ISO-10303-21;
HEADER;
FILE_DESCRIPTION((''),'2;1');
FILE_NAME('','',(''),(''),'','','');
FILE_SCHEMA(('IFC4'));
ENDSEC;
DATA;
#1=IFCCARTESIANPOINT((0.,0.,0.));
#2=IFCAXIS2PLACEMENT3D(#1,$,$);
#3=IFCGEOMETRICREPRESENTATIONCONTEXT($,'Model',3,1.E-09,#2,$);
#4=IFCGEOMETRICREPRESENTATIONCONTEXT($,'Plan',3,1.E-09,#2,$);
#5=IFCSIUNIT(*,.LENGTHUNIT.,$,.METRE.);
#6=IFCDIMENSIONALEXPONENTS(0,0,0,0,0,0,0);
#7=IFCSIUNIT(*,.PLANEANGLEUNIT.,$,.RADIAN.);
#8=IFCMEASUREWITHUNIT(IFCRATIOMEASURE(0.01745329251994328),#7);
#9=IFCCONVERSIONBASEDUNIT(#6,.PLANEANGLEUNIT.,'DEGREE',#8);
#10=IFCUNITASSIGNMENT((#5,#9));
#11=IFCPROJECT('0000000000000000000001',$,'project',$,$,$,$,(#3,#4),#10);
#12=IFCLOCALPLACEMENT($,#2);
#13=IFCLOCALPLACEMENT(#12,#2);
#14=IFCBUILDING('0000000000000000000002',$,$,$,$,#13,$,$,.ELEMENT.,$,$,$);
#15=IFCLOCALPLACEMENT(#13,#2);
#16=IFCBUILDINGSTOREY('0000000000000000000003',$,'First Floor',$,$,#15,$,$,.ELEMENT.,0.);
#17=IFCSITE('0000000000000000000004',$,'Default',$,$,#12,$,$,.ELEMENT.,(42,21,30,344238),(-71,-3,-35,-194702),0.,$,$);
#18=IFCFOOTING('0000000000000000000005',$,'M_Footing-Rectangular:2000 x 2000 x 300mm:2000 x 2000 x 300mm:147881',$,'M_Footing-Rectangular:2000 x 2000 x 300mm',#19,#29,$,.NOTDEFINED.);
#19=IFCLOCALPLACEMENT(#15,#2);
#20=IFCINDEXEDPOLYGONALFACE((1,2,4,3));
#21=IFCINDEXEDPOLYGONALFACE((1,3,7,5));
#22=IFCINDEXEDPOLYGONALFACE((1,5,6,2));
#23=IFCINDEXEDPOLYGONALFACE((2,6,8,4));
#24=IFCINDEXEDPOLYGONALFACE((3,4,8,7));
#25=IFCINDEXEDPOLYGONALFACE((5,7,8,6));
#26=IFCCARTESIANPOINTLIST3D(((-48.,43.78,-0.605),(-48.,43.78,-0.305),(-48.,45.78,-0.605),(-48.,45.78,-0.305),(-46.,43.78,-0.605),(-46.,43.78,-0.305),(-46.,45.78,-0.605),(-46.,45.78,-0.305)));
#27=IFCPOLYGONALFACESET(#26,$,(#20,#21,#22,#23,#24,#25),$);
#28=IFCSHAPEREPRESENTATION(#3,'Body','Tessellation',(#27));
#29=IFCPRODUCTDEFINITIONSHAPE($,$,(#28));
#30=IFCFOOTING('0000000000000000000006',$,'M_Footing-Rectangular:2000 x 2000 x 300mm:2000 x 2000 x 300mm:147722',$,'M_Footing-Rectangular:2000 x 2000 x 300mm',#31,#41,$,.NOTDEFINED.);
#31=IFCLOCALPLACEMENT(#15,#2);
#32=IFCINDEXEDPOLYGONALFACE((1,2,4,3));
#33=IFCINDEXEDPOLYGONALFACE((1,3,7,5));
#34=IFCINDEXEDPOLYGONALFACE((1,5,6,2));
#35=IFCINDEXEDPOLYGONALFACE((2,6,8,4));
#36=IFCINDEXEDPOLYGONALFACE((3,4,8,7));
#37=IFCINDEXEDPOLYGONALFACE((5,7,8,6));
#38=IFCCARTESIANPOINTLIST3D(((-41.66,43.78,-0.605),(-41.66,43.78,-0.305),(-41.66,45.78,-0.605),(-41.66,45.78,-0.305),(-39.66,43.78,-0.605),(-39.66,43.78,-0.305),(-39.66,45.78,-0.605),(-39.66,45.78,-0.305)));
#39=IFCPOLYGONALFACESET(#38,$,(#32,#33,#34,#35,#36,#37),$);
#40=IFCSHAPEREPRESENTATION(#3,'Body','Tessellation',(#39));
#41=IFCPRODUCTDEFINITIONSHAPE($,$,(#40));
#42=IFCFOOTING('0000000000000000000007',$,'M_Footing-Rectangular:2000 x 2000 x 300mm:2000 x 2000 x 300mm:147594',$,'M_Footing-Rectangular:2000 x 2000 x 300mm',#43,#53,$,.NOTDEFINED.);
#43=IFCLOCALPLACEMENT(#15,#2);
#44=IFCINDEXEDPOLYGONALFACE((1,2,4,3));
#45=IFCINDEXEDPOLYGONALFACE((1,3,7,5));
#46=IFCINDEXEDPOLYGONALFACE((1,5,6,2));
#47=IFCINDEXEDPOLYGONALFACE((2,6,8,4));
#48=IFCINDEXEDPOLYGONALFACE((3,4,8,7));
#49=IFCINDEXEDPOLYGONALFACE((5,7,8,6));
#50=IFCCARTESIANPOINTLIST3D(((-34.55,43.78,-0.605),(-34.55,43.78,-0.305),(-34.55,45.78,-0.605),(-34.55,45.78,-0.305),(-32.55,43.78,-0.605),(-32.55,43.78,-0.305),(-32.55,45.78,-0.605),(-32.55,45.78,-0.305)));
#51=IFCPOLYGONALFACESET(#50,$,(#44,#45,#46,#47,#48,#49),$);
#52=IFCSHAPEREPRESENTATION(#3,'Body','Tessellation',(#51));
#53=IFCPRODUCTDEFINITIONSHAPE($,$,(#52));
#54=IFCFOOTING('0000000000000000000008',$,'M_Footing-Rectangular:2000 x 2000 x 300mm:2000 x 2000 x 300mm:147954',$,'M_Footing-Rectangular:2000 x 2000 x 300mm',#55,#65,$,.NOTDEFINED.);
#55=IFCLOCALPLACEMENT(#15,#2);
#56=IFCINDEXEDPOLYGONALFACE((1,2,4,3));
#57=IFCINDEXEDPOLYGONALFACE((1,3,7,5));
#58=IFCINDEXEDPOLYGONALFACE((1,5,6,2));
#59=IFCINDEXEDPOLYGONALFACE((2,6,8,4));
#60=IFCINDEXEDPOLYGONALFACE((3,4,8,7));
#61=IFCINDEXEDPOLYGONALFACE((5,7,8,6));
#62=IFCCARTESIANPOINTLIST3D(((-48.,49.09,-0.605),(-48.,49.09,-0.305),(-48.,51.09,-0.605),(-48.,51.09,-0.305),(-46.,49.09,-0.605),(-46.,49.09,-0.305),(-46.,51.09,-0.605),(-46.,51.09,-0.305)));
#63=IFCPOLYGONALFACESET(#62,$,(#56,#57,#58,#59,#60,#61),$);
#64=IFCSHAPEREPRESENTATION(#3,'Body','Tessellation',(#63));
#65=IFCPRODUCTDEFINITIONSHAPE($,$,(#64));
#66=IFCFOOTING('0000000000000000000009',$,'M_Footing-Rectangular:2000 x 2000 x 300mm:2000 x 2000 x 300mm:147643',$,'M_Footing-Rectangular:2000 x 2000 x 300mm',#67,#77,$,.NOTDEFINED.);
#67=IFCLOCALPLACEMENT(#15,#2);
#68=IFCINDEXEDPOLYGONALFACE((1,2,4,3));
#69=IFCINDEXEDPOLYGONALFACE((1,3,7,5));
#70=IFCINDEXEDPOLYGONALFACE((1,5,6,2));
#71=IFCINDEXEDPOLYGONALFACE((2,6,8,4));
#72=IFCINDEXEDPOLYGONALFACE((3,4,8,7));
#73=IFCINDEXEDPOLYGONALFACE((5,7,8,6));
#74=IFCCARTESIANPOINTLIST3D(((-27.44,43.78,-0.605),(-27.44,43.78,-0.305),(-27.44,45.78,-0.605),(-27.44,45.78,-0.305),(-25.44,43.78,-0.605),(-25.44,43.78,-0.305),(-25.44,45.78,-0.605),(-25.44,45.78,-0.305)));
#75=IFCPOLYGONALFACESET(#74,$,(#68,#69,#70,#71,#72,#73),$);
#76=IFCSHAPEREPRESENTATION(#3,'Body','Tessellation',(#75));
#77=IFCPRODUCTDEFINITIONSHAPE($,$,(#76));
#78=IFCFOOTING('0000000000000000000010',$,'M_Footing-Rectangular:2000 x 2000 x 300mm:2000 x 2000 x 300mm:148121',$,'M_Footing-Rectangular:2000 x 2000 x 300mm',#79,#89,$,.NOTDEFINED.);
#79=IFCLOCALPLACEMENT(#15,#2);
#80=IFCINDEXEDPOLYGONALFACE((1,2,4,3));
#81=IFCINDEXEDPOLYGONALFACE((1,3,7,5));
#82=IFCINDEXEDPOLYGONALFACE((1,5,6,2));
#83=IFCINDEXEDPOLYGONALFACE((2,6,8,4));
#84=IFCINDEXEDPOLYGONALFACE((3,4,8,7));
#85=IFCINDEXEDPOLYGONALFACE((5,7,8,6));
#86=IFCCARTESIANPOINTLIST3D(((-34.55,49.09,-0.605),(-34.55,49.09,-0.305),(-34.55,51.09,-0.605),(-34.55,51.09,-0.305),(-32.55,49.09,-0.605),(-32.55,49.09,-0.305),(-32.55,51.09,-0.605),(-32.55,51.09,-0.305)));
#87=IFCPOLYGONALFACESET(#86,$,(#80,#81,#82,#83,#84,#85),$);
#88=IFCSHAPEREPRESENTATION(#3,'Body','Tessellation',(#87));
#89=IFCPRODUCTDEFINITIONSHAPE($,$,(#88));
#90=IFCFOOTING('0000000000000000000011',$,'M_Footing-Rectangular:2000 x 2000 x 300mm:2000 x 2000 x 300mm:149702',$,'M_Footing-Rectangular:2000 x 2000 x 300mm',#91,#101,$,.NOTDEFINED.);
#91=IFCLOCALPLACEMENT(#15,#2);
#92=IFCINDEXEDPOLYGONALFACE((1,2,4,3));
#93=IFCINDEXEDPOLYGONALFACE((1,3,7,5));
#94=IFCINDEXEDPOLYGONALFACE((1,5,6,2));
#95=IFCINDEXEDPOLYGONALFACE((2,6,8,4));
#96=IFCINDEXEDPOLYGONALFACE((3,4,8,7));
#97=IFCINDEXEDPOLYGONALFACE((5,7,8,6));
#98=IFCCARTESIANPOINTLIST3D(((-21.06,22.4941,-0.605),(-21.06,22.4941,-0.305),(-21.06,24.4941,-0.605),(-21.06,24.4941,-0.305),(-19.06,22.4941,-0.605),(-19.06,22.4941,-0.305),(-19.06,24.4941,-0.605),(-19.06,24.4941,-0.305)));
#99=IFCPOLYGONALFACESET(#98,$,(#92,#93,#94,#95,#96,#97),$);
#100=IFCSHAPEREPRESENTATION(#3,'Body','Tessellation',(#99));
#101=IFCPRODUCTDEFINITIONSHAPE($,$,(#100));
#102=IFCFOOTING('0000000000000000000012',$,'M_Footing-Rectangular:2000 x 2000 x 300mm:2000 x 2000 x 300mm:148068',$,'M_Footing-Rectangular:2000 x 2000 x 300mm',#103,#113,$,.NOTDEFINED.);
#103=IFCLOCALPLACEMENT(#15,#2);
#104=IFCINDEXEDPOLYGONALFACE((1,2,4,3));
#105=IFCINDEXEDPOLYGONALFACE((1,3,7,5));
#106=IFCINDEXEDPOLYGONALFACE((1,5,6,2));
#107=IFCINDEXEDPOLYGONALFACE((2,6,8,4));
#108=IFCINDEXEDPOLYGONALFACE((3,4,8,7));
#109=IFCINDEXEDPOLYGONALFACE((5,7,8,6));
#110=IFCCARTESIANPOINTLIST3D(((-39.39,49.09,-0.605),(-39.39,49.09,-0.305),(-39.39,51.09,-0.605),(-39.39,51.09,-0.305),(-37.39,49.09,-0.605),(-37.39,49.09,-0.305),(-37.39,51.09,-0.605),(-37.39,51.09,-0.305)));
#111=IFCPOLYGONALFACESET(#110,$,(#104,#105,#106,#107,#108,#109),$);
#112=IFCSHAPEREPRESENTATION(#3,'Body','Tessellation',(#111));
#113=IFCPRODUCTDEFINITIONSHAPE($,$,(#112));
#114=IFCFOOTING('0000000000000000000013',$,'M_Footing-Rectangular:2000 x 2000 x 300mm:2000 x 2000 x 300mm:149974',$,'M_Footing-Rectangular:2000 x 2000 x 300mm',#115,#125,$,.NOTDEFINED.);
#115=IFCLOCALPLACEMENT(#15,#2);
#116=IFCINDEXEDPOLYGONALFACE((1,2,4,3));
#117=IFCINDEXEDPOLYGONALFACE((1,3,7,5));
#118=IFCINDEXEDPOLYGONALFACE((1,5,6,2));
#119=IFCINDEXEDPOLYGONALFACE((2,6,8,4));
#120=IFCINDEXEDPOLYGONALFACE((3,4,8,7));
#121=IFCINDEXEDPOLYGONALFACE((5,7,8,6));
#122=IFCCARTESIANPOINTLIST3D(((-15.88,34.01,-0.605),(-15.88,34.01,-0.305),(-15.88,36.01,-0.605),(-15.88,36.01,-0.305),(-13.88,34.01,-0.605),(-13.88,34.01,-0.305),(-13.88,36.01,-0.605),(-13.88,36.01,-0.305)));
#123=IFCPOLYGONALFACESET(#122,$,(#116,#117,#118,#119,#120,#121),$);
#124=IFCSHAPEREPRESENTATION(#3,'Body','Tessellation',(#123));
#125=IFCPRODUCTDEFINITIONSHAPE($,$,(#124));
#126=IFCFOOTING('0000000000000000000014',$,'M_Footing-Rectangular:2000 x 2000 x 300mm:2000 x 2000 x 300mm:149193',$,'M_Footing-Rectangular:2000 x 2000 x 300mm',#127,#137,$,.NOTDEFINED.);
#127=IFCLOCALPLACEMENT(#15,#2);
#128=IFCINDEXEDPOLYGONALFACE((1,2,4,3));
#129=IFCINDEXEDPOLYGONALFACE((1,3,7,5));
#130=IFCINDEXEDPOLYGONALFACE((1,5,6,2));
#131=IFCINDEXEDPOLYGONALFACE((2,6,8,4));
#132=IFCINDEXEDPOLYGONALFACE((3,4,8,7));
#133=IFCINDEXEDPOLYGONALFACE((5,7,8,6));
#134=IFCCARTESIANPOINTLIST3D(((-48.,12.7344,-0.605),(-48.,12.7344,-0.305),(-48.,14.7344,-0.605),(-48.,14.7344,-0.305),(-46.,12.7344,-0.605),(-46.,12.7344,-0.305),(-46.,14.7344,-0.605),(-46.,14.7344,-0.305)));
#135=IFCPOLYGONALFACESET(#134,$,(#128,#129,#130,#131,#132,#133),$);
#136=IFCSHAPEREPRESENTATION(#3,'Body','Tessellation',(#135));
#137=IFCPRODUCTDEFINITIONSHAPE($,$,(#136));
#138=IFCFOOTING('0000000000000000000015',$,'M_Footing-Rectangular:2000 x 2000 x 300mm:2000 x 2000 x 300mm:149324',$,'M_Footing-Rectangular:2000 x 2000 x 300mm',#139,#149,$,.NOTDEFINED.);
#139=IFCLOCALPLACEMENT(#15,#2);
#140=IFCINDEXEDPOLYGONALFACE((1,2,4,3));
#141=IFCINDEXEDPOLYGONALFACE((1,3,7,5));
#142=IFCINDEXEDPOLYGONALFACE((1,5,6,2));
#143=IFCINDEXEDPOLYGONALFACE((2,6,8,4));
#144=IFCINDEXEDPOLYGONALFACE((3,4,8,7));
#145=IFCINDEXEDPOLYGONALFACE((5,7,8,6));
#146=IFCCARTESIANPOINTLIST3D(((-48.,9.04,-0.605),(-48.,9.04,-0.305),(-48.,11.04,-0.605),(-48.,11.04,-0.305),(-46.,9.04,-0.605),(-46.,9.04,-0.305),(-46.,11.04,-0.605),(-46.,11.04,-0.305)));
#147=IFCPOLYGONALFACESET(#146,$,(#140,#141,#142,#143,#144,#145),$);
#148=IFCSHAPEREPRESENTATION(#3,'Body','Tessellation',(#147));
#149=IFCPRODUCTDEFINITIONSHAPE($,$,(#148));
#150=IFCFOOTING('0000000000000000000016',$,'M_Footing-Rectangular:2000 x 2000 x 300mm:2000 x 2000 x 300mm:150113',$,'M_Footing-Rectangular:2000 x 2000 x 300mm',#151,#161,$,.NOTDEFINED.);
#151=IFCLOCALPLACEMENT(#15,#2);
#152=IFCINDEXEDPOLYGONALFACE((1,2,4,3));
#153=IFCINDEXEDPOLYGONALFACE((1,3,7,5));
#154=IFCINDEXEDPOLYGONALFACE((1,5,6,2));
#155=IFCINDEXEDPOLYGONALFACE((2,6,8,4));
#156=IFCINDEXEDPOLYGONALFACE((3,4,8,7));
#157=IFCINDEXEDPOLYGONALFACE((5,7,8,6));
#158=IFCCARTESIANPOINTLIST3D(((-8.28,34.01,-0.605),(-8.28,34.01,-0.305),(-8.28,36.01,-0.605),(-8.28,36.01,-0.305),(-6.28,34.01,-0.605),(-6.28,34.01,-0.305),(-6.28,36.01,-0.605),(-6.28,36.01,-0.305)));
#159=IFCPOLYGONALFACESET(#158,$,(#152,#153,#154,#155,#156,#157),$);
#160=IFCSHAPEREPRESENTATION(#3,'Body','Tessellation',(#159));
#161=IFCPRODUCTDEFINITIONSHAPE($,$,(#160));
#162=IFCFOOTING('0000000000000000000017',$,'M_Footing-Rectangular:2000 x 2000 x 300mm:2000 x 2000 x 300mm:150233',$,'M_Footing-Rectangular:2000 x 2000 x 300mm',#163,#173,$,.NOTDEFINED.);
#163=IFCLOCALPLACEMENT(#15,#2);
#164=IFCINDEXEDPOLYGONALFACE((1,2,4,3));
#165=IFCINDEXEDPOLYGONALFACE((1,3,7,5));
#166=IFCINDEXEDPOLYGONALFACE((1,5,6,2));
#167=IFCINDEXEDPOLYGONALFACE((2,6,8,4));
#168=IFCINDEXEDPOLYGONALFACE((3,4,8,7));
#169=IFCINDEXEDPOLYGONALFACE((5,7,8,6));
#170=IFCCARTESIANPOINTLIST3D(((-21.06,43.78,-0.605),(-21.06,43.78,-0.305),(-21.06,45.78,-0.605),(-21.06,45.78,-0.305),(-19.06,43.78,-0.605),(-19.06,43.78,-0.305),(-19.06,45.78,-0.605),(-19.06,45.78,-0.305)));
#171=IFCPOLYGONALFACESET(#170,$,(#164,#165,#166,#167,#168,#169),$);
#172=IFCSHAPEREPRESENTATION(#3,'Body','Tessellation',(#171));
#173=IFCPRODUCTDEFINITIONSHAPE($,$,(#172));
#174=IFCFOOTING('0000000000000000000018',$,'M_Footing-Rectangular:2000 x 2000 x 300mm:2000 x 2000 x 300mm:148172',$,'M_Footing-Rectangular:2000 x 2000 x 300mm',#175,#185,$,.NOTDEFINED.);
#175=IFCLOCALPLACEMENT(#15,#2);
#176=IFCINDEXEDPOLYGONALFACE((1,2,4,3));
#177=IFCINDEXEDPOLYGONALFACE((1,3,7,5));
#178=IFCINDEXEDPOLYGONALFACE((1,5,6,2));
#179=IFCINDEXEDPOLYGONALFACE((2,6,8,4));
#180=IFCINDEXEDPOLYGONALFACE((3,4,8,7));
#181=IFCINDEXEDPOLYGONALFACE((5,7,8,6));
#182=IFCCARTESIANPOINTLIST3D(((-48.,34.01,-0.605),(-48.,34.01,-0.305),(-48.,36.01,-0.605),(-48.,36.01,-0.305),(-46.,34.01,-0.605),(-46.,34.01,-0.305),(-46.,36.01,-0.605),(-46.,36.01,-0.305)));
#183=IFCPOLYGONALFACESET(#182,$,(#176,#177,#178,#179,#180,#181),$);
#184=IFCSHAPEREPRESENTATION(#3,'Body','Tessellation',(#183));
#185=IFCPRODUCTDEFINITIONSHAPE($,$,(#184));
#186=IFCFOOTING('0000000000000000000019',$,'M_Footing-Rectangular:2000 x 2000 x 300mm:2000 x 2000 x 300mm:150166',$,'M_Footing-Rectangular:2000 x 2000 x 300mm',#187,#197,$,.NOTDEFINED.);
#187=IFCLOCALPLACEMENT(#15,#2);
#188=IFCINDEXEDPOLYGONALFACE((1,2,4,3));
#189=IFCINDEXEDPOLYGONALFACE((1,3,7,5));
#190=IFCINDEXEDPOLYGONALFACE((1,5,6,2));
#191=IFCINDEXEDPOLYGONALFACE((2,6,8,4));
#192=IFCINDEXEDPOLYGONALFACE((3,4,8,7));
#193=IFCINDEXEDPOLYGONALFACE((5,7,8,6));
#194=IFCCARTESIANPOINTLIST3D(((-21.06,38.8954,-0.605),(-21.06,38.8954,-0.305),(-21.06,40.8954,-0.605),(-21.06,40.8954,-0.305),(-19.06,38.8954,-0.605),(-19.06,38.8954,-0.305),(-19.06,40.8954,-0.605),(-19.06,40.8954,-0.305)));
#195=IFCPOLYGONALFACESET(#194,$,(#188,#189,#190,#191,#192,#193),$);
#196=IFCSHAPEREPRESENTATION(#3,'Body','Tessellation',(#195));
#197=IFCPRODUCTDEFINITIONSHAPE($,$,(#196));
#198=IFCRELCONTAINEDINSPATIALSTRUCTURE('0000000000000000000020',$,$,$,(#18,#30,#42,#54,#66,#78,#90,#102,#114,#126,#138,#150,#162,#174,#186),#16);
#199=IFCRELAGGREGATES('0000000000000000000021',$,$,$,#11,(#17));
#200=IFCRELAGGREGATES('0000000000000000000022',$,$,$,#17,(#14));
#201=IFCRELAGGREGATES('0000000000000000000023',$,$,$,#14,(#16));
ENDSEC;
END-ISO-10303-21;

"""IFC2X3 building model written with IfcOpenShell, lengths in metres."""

from ifc_helpers import new_model, entity, si_unit, converted_unit, frame, origin, origin_2d_with_axis, place, context, project, spatial, rectangle, extrude, element, save


model = new_model("IFC2X3")

# Units and contexts
model_context = context("Model", 3, precision=1e-09, world=origin())
plan_context = context("Plan", 3, precision=1e-09, world=origin())
ifc_project = project(units=[si_unit("LENGTHUNIT", "METRE"), converted_unit("PLANEANGLEUNIT", "DEGREE", entity("IfcRatioMeasure", 0.01745329251994328), si_unit("PLANEANGLEUNIT", "RADIAN"), dimensions=[0, 0, 0, 0, 0, 0, 0])], contexts=[model_context, plan_context])

# Site, building, storey
site_placement = place(None, origin())
site = spatial("IfcSite", under=ifc_project, at=site_placement, Name="Default", CompositionType="ELEMENT", RefLatitude=(42, 21, 30, 344238), RefLongitude=(-71, -3, -35, -194702), RefElevation=0.0)
building_placement = place(site_placement, origin())
building = spatial("IfcBuilding", under=site, at=building_placement, CompositionType="ELEMENT")
storey_placement = place(building_placement, origin())
storey = spatial("IfcBuildingStorey", under=building, at=storey_placement, Name="First Floor", CompositionType="ELEMENT", Elevation=0.0)

# Footings
footing_1_placement = place(storey_placement, origin())
element("IfcFooting", 1, at=footing_1_placement, inside=storey, Name="M_Footing-Rectangular:2000 x 2000 x 300mm:2000 x 2000 x 300mm:147881", ObjectType="M_Footing-Rectangular:2000 x 2000 x 300mm", PredefinedType="NOTDEFINED", context=model_context, shape_type="SweptSolid", body=[
    extrude(rectangle(XDim=2.0, YDim=2.0, at=origin_2d_with_axis()), frame((-47.0, 44.78, -0.605), z_axis=(0.0, 0.0, 1.0), x_axis=(-1.0, 0.0, 0.0)), (0.0, 0.0, 1.0), 0.3),
])
footing_2_placement = place(storey_placement, origin())
element("IfcFooting", 2, at=footing_2_placement, inside=storey, Name="M_Footing-Rectangular:2000 x 2000 x 300mm:2000 x 2000 x 300mm:147722", ObjectType="M_Footing-Rectangular:2000 x 2000 x 300mm", PredefinedType="NOTDEFINED", context=model_context, shape_type="SweptSolid", body=[
    extrude(rectangle(XDim=2.0, YDim=2.0, at=origin_2d_with_axis()), frame((-40.66, 44.78, -0.605), z_axis=(0.0, 0.0, 1.0), x_axis=(-1.0, 0.0, 0.0)), (0.0, 0.0, 1.0), 0.3),
])
footing_3_placement = place(storey_placement, origin())
element("IfcFooting", 3, at=footing_3_placement, inside=storey, Name="M_Footing-Rectangular:2000 x 2000 x 300mm:2000 x 2000 x 300mm:147594", ObjectType="M_Footing-Rectangular:2000 x 2000 x 300mm", PredefinedType="NOTDEFINED", context=model_context, shape_type="SweptSolid", body=[
    extrude(rectangle(XDim=2.0, YDim=2.0, at=origin_2d_with_axis()), frame((-33.55, 44.78, -0.605), z_axis=(0.0, 0.0, 1.0), x_axis=(-1.0, 0.0, 0.0)), (0.0, 0.0, 1.0), 0.3),
])
footing_4_placement = place(storey_placement, origin())
element("IfcFooting", 4, at=footing_4_placement, inside=storey, Name="M_Footing-Rectangular:2000 x 2000 x 300mm:2000 x 2000 x 300mm:147954", ObjectType="M_Footing-Rectangular:2000 x 2000 x 300mm", PredefinedType="NOTDEFINED", context=model_context, shape_type="SweptSolid", body=[
    extrude(rectangle(XDim=2.0, YDim=2.0, at=origin_2d_with_axis()), frame((-47.0, 50.09, -0.605), z_axis=(0.0, 0.0, 1.0), x_axis=(-1.0, 0.0, 0.0)), (0.0, 0.0, 1.0), 0.3),
])
footing_5_placement = place(storey_placement, origin())
element("IfcFooting", 5, at=footing_5_placement, inside=storey, Name="M_Footing-Rectangular:2000 x 2000 x 300mm:2000 x 2000 x 300mm:147643", ObjectType="M_Footing-Rectangular:2000 x 2000 x 300mm", PredefinedType="NOTDEFINED", context=model_context, shape_type="SweptSolid", body=[
    extrude(rectangle(XDim=2.0, YDim=2.0, at=origin_2d_with_axis()), frame((-26.44, 44.78, -0.605), z_axis=(0.0, 0.0, 1.0), x_axis=(-1.0, 0.0, 0.0)), (0.0, 0.0, 1.0), 0.3),
])
footing_6_placement = place(storey_placement, origin())
element("IfcFooting", 6, at=footing_6_placement, inside=storey, Name="M_Footing-Rectangular:2000 x 2000 x 300mm:2000 x 2000 x 300mm:148121", ObjectType="M_Footing-Rectangular:2000 x 2000 x 300mm", PredefinedType="NOTDEFINED", context=model_context, shape_type="SweptSolid", body=[
    extrude(rectangle(XDim=2.0, YDim=2.0, at=origin_2d_with_axis()), frame((-33.55, 50.09, -0.605), z_axis=(0.0, 0.0, 1.0), x_axis=(-1.0, 0.0, 0.0)), (0.0, 0.0, 1.0), 0.3),
])
footing_7_placement = place(storey_placement, origin())
element("IfcFooting", 7, at=footing_7_placement, inside=storey, Name="M_Footing-Rectangular:2000 x 2000 x 300mm:2000 x 2000 x 300mm:149702", ObjectType="M_Footing-Rectangular:2000 x 2000 x 300mm", PredefinedType="NOTDEFINED", context=model_context, shape_type="SweptSolid", body=[
    extrude(rectangle(XDim=2.0, YDim=2.0, at=origin_2d_with_axis()), frame((-20.06, 23.4941, -0.605), z_axis=(0.0, 0.0, 1.0), x_axis=(-1.0, 0.0, 0.0)), (0.0, 0.0, 1.0), 0.3),
])
footing_8_placement = place(storey_placement, origin())
element("IfcFooting", 8, at=footing_8_placement, inside=storey, Name="M_Footing-Rectangular:2000 x 2000 x 300mm:2000 x 2000 x 300mm:148068", ObjectType="M_Footing-Rectangular:2000 x 2000 x 300mm", PredefinedType="NOTDEFINED", context=model_context, shape_type="SweptSolid", body=[
    extrude(rectangle(XDim=2.0, YDim=2.0, at=origin_2d_with_axis()), frame((-38.39, 50.09, -0.605), z_axis=(0.0, 0.0, 1.0), x_axis=(-1.0, 0.0, 0.0)), (0.0, 0.0, 1.0), 0.3),
])
footing_9_placement = place(storey_placement, origin())
element("IfcFooting", 9, at=footing_9_placement, inside=storey, Name="M_Footing-Rectangular:2000 x 2000 x 300mm:2000 x 2000 x 300mm:149974", ObjectType="M_Footing-Rectangular:2000 x 2000 x 300mm", PredefinedType="NOTDEFINED", context=model_context, shape_type="SweptSolid", body=[
    extrude(rectangle(XDim=2.0, YDim=2.0, at=origin_2d_with_axis()), frame((-14.88, 35.01, -0.605), z_axis=(0.0, 0.0, 1.0), x_axis=(-1.0, 0.0, 0.0)), (0.0, 0.0, 1.0), 0.3),
])
footing_10_placement = place(storey_placement, origin())
element("IfcFooting", 10, at=footing_10_placement, inside=storey, Name="M_Footing-Rectangular:2000 x 2000 x 300mm:2000 x 2000 x 300mm:149193", ObjectType="M_Footing-Rectangular:2000 x 2000 x 300mm", PredefinedType="NOTDEFINED", context=model_context, shape_type="SweptSolid", body=[
    extrude(rectangle(XDim=2.0, YDim=2.0, at=origin_2d_with_axis()), frame((-47.0, 13.7344, -0.605), z_axis=(0.0, 0.0, 1.0), x_axis=(-1.0, 0.0, 0.0)), (0.0, 0.0, 1.0), 0.3),
])
footing_11_placement = place(storey_placement, origin())
element("IfcFooting", 11, at=footing_11_placement, inside=storey, Name="M_Footing-Rectangular:2000 x 2000 x 300mm:2000 x 2000 x 300mm:149324", ObjectType="M_Footing-Rectangular:2000 x 2000 x 300mm", PredefinedType="NOTDEFINED", context=model_context, shape_type="SweptSolid", body=[
    extrude(rectangle(XDim=2.0, YDim=2.0, at=origin_2d_with_axis()), frame((-47.0, 10.04, -0.605), z_axis=(0.0, 0.0, 1.0), x_axis=(-1.0, 0.0, 0.0)), (0.0, 0.0, 1.0), 0.3),
])
footing_12_placement = place(storey_placement, origin())
element("IfcFooting", 12, at=footing_12_placement, inside=storey, Name="M_Footing-Rectangular:2000 x 2000 x 300mm:2000 x 2000 x 300mm:150113", ObjectType="M_Footing-Rectangular:2000 x 2000 x 300mm", PredefinedType="NOTDEFINED", context=model_context, shape_type="SweptSolid", body=[
    extrude(rectangle(XDim=2.0, YDim=2.0, at=origin_2d_with_axis()), frame((-7.28, 35.01, -0.605), z_axis=(0.0, 0.0, 1.0), x_axis=(-1.0, 0.0, 0.0)), (0.0, 0.0, 1.0), 0.3),
])
footing_13_placement = place(storey_placement, origin())
element("IfcFooting", 13, at=footing_13_placement, inside=storey, Name="M_Footing-Rectangular:2000 x 2000 x 300mm:2000 x 2000 x 300mm:150233", ObjectType="M_Footing-Rectangular:2000 x 2000 x 300mm", PredefinedType="NOTDEFINED", context=model_context, shape_type="SweptSolid", body=[
    extrude(rectangle(XDim=2.0, YDim=2.0, at=origin_2d_with_axis()), frame((-20.06, 44.78, -0.605), z_axis=(0.0, 0.0, 1.0), x_axis=(-1.0, 0.0, 0.0)), (0.0, 0.0, 1.0), 0.3),
])
footing_14_placement = place(storey_placement, origin())
element("IfcFooting", 14, at=footing_14_placement, inside=storey, Name="M_Footing-Rectangular:2000 x 2000 x 300mm:2000 x 2000 x 300mm:148172", ObjectType="M_Footing-Rectangular:2000 x 2000 x 300mm", PredefinedType="NOTDEFINED", context=model_context, shape_type="SweptSolid", body=[
    extrude(rectangle(XDim=2.0, YDim=2.0, at=origin_2d_with_axis()), frame((-47.0, 35.01, -0.605), z_axis=(0.0, 0.0, 1.0), x_axis=(-1.0, 0.0, 0.0)), (0.0, 0.0, 1.0), 0.3),
])
footing_15_placement = place(storey_placement, origin())
element("IfcFooting", 15, at=footing_15_placement, inside=storey, Name="M_Footing-Rectangular:2000 x 2000 x 300mm:2000 x 2000 x 300mm:150166", ObjectType="M_Footing-Rectangular:2000 x 2000 x 300mm", PredefinedType="NOTDEFINED", context=model_context, shape_type="SweptSolid", body=[
    extrude(rectangle(XDim=2.0, YDim=2.0, at=origin_2d_with_axis()), frame((-20.06, 39.8954, -0.605), z_axis=(0.0, 0.0, 1.0), x_axis=(-1.0, 0.0, 0.0)), (0.0, 0.0, 1.0), 0.3),
])

save(model, "model.ifc")
